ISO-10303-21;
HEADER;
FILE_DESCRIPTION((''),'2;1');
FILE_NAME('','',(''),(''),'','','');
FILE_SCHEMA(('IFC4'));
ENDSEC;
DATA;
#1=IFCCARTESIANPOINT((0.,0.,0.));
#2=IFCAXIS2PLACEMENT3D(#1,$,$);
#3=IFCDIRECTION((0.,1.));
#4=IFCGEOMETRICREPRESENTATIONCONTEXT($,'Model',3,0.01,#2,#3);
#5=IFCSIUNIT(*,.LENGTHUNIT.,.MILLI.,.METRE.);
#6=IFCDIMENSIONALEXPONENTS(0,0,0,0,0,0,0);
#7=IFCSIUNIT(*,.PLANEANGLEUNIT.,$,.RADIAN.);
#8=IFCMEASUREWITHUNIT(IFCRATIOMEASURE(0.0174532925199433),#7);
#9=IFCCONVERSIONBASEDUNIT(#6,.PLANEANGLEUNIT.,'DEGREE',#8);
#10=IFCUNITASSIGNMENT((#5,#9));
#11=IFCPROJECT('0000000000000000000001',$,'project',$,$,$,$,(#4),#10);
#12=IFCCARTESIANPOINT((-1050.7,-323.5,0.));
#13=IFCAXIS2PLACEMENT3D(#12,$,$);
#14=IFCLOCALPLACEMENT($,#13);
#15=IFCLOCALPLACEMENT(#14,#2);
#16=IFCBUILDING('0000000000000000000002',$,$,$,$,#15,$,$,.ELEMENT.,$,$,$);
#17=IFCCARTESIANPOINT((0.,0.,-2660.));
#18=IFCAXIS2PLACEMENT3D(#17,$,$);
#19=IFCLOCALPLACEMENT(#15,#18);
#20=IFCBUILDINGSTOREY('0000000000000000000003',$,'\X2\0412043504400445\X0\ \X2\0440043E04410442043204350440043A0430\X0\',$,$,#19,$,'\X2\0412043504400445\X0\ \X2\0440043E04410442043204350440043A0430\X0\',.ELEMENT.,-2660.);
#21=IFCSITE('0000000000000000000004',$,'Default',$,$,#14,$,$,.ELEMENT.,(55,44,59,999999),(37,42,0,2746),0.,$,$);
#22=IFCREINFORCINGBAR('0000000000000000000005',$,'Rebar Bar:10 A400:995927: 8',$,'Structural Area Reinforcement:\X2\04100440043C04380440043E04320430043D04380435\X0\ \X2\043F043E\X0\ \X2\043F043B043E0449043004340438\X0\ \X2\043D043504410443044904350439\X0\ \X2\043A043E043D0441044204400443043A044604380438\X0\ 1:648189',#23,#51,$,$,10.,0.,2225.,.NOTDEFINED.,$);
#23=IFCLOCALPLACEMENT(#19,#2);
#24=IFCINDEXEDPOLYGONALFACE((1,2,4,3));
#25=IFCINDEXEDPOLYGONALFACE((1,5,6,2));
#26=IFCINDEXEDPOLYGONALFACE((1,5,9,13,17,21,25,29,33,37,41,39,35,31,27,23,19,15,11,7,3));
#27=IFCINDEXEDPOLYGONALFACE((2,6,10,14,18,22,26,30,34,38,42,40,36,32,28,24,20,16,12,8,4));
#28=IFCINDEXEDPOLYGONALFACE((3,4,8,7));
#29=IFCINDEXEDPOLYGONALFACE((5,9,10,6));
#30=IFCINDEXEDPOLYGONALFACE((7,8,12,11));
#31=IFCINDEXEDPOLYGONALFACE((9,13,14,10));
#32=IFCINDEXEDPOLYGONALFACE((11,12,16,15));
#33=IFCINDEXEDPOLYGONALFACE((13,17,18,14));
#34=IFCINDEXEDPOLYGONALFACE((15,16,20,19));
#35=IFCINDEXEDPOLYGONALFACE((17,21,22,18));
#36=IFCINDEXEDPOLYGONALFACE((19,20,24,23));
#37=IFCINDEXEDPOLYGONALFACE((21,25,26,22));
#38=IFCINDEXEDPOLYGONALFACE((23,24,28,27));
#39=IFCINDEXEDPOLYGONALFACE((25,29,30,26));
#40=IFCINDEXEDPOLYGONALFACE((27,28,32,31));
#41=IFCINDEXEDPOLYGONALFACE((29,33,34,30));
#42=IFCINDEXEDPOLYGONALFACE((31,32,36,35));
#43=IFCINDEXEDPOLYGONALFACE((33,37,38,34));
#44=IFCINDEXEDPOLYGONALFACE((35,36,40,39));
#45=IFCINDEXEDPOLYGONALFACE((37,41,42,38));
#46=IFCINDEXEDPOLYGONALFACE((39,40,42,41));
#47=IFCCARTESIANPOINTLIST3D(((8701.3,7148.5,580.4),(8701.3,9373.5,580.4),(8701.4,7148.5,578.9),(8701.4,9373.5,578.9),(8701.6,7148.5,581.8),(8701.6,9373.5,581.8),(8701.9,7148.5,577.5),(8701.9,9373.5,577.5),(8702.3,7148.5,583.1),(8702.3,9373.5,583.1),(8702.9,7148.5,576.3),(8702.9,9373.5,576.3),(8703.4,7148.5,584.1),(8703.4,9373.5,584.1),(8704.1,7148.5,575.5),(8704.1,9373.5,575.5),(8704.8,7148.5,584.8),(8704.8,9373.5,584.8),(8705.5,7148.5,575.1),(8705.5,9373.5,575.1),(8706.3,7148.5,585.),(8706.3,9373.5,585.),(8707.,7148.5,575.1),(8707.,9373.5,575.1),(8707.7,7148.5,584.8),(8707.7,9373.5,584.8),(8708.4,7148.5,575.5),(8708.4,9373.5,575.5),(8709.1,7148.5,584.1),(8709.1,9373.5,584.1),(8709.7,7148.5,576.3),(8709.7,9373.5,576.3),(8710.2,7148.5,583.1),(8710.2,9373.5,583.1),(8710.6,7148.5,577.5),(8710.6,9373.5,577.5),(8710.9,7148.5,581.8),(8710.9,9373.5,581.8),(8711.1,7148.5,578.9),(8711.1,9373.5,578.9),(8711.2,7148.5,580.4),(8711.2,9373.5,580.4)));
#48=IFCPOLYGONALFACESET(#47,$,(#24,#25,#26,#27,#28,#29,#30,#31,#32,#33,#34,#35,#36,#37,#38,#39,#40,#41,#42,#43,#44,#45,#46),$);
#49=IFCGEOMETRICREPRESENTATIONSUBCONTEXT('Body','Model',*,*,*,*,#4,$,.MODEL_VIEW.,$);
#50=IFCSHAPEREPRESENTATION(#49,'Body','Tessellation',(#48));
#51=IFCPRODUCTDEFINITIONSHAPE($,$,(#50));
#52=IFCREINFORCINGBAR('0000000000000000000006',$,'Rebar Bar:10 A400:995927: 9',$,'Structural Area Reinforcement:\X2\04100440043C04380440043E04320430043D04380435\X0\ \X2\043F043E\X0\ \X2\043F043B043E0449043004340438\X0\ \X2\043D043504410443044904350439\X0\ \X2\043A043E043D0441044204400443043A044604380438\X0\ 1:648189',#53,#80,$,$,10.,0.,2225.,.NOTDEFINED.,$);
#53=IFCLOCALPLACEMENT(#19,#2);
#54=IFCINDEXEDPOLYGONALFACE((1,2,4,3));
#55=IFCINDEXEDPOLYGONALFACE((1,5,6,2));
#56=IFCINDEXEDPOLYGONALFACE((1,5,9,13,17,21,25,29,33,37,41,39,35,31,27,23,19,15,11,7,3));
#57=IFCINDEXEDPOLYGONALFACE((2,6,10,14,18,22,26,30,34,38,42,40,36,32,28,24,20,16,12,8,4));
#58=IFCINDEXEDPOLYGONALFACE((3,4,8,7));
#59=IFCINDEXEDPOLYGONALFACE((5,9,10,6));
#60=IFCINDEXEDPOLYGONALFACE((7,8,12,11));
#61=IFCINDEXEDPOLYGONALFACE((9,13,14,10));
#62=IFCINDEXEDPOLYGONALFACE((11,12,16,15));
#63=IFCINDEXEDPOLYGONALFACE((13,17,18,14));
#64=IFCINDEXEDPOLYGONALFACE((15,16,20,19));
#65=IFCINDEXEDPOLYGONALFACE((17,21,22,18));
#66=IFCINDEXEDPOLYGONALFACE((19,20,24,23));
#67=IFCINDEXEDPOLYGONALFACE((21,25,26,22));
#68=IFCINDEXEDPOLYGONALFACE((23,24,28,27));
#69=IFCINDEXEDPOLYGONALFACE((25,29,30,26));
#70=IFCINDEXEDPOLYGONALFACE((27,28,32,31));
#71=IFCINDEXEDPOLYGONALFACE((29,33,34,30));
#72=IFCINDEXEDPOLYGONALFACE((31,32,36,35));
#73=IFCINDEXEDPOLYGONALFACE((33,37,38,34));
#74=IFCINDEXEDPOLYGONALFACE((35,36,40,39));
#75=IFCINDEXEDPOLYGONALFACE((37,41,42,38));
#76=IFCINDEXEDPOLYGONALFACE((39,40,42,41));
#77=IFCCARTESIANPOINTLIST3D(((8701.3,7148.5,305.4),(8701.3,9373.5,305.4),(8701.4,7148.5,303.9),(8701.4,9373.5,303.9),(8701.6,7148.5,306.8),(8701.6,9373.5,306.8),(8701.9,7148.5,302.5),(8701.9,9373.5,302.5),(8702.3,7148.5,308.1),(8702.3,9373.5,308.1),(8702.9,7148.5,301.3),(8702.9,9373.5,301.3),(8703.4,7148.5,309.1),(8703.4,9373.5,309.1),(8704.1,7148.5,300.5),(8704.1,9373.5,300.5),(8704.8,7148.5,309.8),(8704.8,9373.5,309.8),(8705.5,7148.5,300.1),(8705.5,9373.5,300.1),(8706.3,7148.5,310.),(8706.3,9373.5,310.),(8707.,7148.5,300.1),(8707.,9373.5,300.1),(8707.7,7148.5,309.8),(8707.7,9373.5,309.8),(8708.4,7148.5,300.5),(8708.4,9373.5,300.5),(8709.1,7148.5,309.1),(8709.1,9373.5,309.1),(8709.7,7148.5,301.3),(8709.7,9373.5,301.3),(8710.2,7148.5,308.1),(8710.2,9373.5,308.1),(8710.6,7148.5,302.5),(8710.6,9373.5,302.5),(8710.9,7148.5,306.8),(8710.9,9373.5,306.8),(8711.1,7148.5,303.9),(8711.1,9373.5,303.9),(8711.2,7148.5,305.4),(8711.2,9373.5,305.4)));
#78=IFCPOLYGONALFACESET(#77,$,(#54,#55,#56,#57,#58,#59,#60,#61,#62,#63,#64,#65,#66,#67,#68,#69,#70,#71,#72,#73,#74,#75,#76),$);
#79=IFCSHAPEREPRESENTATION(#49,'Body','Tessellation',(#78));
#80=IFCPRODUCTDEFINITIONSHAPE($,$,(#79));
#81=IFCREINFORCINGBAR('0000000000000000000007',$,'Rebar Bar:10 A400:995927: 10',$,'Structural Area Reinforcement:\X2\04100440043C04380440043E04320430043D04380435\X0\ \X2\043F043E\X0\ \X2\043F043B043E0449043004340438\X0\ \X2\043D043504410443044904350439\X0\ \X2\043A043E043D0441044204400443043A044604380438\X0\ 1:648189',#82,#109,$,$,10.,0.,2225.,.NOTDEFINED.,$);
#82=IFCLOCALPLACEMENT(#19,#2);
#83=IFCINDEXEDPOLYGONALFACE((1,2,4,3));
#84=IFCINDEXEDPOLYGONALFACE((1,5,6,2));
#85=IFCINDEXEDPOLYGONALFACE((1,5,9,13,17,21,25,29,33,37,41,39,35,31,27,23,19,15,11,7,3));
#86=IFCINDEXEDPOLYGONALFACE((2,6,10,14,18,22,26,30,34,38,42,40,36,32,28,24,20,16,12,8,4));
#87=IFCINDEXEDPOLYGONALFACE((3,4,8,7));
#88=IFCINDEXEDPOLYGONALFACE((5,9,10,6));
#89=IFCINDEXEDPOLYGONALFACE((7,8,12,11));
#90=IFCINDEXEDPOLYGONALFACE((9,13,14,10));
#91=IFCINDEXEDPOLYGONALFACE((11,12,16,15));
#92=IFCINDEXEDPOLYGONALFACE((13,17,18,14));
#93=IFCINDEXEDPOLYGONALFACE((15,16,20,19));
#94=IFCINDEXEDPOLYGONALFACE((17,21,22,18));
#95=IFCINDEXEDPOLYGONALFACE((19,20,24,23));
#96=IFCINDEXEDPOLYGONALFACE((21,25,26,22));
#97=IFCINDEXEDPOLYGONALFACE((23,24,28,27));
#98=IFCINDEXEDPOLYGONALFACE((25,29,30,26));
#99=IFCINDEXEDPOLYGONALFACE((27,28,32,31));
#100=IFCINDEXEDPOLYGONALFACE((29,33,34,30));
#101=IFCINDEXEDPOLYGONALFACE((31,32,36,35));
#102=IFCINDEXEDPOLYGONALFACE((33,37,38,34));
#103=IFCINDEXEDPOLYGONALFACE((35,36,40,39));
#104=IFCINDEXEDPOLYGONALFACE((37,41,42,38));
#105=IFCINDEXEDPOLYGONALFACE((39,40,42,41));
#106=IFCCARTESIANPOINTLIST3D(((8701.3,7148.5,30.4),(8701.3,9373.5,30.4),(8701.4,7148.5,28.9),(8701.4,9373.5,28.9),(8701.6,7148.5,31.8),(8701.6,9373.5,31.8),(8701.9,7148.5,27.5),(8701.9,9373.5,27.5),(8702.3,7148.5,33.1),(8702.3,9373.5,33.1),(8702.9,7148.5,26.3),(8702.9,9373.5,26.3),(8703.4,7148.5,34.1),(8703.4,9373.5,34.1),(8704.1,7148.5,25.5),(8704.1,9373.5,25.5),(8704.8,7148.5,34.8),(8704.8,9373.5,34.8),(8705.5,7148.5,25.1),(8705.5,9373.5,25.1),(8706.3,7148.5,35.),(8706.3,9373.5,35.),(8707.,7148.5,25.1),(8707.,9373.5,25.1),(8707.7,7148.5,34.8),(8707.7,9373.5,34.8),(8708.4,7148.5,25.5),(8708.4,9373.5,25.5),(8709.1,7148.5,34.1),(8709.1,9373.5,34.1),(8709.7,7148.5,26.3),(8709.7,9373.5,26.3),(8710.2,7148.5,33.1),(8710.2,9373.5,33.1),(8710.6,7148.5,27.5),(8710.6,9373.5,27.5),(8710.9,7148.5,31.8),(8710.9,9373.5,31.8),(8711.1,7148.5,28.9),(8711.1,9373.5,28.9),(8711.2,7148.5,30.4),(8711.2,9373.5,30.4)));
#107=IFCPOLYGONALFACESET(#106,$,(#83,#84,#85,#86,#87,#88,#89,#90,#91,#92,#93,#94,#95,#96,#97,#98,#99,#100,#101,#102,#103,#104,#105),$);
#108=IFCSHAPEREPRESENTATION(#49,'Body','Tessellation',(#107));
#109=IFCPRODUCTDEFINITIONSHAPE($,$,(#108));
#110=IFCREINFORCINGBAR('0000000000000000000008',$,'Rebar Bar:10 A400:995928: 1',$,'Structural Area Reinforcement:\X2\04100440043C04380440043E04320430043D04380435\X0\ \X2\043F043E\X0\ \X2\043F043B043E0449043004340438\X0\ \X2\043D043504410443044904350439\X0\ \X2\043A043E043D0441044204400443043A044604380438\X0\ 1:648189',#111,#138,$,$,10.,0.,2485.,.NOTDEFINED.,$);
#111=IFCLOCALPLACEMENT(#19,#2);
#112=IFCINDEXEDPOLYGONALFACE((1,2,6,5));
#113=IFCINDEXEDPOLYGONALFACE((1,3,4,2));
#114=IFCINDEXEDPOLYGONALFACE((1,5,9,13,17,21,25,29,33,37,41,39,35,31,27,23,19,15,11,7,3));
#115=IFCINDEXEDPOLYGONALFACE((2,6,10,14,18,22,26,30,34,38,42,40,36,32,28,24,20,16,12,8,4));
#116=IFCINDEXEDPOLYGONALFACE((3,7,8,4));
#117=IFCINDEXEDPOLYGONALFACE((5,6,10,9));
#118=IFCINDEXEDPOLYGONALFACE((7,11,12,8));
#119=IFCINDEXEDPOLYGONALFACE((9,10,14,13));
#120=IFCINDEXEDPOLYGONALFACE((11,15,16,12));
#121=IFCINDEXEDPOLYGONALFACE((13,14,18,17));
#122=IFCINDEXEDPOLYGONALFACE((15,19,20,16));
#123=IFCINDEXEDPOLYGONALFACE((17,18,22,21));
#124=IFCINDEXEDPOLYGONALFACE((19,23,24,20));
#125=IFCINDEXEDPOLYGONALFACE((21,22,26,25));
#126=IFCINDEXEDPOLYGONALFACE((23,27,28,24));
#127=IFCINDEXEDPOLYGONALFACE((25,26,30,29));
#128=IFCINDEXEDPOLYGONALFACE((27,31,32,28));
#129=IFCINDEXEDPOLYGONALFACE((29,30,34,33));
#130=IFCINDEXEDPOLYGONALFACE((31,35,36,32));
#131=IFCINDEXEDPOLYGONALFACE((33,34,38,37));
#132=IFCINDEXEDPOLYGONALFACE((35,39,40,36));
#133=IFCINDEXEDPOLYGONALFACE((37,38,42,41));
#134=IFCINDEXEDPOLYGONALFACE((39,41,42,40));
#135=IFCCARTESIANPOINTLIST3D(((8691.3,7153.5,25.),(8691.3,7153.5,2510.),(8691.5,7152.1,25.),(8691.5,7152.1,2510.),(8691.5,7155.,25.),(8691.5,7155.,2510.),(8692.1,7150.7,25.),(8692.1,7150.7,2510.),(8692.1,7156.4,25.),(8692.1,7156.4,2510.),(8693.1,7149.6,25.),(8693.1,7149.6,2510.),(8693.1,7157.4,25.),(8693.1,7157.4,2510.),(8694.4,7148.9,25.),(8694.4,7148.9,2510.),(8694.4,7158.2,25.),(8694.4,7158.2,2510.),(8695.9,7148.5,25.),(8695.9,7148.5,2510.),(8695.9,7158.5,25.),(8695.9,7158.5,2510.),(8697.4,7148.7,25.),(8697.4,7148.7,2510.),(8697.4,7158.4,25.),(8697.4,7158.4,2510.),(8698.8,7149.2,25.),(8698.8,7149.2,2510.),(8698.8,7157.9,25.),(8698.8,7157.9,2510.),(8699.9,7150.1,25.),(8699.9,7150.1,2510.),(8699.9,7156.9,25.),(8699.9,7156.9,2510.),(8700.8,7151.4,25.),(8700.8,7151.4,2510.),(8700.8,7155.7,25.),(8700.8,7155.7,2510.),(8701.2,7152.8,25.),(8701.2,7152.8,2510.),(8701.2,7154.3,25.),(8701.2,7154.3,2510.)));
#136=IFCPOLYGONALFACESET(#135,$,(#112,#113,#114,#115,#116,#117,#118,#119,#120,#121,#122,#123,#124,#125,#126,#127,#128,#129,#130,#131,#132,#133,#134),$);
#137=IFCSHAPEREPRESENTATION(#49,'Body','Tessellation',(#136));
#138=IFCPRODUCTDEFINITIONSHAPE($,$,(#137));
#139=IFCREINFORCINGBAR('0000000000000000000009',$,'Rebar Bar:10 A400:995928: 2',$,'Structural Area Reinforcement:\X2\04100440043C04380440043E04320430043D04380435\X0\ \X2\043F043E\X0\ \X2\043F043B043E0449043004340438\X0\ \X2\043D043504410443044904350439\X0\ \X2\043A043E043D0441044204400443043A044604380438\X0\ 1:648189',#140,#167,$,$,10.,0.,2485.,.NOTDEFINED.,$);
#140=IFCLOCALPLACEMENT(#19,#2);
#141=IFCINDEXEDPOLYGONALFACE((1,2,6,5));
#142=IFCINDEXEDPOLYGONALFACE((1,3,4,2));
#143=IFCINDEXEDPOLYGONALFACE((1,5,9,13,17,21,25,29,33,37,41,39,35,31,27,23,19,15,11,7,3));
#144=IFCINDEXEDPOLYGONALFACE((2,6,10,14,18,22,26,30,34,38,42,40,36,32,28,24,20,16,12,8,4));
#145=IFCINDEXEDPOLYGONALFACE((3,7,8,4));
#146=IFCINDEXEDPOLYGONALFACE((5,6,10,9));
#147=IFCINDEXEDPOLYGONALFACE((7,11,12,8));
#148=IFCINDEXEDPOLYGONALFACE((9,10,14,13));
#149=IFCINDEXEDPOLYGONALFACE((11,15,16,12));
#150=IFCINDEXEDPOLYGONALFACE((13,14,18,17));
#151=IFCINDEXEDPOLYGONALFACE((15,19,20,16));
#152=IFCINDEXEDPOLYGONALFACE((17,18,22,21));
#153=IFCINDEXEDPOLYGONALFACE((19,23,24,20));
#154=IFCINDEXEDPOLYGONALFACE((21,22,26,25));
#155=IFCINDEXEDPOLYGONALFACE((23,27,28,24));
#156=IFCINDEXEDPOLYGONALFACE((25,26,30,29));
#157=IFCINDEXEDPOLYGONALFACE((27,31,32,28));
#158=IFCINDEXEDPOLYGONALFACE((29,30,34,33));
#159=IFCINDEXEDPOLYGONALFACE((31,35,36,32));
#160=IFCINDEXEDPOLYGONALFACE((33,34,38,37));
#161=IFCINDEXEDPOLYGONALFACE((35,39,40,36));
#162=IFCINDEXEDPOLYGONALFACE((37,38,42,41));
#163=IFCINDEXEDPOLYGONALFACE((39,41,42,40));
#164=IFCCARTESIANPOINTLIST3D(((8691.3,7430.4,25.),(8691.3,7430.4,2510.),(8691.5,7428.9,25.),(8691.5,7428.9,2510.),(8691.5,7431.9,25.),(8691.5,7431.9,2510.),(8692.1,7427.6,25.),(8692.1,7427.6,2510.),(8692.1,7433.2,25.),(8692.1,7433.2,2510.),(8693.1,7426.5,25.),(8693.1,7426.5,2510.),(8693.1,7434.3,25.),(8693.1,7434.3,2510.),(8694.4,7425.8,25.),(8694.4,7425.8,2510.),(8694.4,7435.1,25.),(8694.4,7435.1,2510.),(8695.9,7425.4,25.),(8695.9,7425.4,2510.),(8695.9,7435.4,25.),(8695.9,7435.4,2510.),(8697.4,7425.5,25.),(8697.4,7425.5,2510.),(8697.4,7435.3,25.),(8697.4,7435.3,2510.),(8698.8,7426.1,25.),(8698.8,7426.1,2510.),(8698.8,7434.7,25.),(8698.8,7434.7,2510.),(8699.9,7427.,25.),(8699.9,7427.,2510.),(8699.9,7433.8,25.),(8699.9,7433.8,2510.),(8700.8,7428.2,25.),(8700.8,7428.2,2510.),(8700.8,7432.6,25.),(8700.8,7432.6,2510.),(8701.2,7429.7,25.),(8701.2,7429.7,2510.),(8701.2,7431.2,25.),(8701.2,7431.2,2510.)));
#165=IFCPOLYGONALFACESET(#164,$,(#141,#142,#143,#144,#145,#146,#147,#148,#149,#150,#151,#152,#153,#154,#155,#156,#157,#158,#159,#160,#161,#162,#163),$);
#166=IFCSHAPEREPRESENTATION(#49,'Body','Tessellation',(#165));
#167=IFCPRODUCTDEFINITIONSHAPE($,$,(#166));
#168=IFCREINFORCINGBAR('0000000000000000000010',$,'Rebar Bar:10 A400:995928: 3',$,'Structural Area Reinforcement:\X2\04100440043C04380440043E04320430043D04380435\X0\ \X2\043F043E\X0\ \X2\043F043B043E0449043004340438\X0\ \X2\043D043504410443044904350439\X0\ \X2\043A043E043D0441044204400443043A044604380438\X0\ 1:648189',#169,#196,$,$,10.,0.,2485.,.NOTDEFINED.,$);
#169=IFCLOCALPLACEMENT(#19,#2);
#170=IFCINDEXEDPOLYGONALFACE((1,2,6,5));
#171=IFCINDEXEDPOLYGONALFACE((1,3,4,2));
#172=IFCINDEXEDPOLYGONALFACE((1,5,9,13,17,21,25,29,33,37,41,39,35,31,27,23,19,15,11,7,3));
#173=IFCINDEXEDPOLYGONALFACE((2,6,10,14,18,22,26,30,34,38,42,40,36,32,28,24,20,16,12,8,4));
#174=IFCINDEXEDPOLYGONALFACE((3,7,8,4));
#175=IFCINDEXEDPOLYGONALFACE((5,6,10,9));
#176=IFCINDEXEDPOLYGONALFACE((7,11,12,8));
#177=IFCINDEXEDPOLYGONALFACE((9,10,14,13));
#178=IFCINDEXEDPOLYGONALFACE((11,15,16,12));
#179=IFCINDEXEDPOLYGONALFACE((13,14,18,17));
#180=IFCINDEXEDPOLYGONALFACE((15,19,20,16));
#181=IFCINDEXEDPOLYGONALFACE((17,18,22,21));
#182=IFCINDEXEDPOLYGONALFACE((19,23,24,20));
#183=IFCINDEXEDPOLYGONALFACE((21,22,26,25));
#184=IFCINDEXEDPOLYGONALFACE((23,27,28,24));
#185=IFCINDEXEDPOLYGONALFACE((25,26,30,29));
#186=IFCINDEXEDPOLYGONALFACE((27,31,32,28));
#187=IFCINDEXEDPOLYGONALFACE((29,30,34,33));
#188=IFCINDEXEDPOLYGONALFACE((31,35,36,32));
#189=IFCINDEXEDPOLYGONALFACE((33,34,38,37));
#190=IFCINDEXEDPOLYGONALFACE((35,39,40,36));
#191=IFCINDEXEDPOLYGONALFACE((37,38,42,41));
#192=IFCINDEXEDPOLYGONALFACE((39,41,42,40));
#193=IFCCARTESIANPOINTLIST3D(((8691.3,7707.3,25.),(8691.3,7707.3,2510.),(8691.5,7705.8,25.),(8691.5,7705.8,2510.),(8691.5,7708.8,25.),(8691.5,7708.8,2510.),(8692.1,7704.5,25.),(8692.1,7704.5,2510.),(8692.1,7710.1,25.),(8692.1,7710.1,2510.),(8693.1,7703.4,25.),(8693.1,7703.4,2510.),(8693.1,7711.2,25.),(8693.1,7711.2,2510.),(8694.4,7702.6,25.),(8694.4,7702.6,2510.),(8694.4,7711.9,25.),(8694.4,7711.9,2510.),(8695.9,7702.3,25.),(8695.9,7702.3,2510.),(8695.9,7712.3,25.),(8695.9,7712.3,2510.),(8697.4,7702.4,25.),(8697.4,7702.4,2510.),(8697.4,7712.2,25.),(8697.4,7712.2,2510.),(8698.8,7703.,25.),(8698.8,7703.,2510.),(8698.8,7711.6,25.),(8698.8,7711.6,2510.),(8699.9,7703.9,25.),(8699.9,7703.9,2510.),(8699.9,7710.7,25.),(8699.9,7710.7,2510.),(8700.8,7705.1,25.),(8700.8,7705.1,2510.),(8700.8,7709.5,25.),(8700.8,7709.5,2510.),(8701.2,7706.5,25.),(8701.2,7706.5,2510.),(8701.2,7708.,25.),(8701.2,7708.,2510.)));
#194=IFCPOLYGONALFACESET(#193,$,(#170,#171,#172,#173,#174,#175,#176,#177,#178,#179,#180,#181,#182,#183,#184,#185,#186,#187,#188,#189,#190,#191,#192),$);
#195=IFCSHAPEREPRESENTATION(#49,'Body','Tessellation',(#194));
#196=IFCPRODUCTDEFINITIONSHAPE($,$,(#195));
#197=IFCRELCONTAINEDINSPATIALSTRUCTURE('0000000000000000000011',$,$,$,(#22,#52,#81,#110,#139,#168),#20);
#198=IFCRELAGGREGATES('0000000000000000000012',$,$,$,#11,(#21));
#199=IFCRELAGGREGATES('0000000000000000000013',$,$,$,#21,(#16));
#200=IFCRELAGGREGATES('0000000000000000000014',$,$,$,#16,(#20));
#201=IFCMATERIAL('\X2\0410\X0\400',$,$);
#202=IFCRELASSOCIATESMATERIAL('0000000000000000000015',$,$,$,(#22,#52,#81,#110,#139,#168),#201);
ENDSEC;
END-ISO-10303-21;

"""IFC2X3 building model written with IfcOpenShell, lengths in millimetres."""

from ifc_helpers import new_model, entity, si_unit, converted_unit, direction, frame, origin, place, context, subcontext, project, spatial, material, element, save


model = new_model("IFC2X3")

# Units and contexts
model_context = context("Model", 3, precision=0.01, world=origin(), true_north=direction((0.0, 1.0)))
body_context = subcontext(model_context, "Body", "Model", "MODEL_VIEW")
ifc_project = project(units=[si_unit("LENGTHUNIT", "METRE", prefix="MILLI"), converted_unit("PLANEANGLEUNIT", "DEGREE", entity("IfcRatioMeasure", 0.0174532925199433), si_unit("PLANEANGLEUNIT", "RADIAN"), dimensions=[0, 0, 0, 0, 0, 0, 0])], contexts=[model_context])

# Site, building, storey
site_placement = place(None, frame((-1050.7, -323.5, 0.0)))
site = spatial("IfcSite", under=ifc_project, at=site_placement, Name="Default", CompositionType="ELEMENT", RefLatitude=(55, 44, 59, 999999), RefLongitude=(37, 42, 0, 2746), RefElevation=0.0)
building_placement = place(site_placement, origin())
building = spatial("IfcBuilding", under=site, at=building_placement, CompositionType="ELEMENT")
storey_placement = place(building_placement, frame((0.0, 0.0, -2660.0)))
storey = spatial("IfcBuildingStorey", under=building, at=storey_placement, Name="Верх ростверка", LongName="Верх ростверка", CompositionType="ELEMENT", Elevation=-2660.0)

# Reinforcing bars
ifc_material = material(Name="А400")
reinforcing_bar_1_placement = place(storey_placement, origin())
element("IfcReinforcingBar", 1, at=reinforcing_bar_1_placement, inside=storey, material=ifc_material, Name="Rebar Bar:10 A400:995927: 8", ObjectType="Structural Area Reinforcement:Армирование по площади несущей конструкции 1:648189", BarLength=2225.0, BarRole="NOTDEFINED", CrossSectionArea=0.0, NominalDiameter=10.0, context=body_context, shape_type="AdvancedSweptSolid", body=[
    entity("IfcSweptDiskSolid", entity("IfcCompositeCurve", [entity("IfcCompositeCurveSegment", "CONTINUOUS", True, entity("IfcPolyline", [entity("IfcCartesianPoint", [8706.3, 7148.5, 580.0]), entity("IfcCartesianPoint", [8706.3, 9373.5, 580.0])]))], False), 5.0, None, 0.0, 1.0),
])
reinforcing_bar_2_placement = place(storey_placement, origin())
element("IfcReinforcingBar", 2, at=reinforcing_bar_2_placement, inside=storey, material=ifc_material, Name="Rebar Bar:10 A400:995927: 9", ObjectType="Structural Area Reinforcement:Армирование по площади несущей конструкции 1:648189", BarLength=2225.0, BarRole="NOTDEFINED", CrossSectionArea=0.0, NominalDiameter=10.0, context=body_context, shape_type="AdvancedSweptSolid", body=[
    entity("IfcSweptDiskSolid", entity("IfcCompositeCurve", [entity("IfcCompositeCurveSegment", "CONTINUOUS", True, entity("IfcPolyline", [entity("IfcCartesianPoint", [8706.3, 7148.5, 305.0]), entity("IfcCartesianPoint", [8706.3, 9373.5, 305.0])]))], False), 5.0, None, 0.0, 1.0),
])
reinforcing_bar_3_placement = place(storey_placement, origin())
element("IfcReinforcingBar", 3, at=reinforcing_bar_3_placement, inside=storey, material=ifc_material, Name="Rebar Bar:10 A400:995927: 10", ObjectType="Structural Area Reinforcement:Армирование по площади несущей конструкции 1:648189", BarLength=2225.0, BarRole="NOTDEFINED", CrossSectionArea=0.0, NominalDiameter=10.0, context=body_context, shape_type="AdvancedSweptSolid", body=[
    entity("IfcSweptDiskSolid", entity("IfcCompositeCurve", [entity("IfcCompositeCurveSegment", "CONTINUOUS", True, entity("IfcPolyline", [entity("IfcCartesianPoint", [8706.3, 7148.5, 30.0]), entity("IfcCartesianPoint", [8706.3, 9373.5, 30.0])]))], False), 5.0, None, 0.0, 1.0),
])
reinforcing_bar_4_placement = place(storey_placement, origin())
element("IfcReinforcingBar", 4, at=reinforcing_bar_4_placement, inside=storey, material=ifc_material, Name="Rebar Bar:10 A400:995928: 1", ObjectType="Structural Area Reinforcement:Армирование по площади несущей конструкции 1:648189", BarLength=2485.0, BarRole="NOTDEFINED", CrossSectionArea=0.0, NominalDiameter=10.0, context=body_context, shape_type="AdvancedSweptSolid", body=[
    entity("IfcSweptDiskSolid", entity("IfcCompositeCurve", [entity("IfcCompositeCurveSegment", "CONTINUOUS", True, entity("IfcPolyline", [entity("IfcCartesianPoint", [8696.3, 7153.5, 2510.0]), entity("IfcCartesianPoint", [8696.3, 7153.5, 25.0])]))], False), 5.0, None, 0.0, 1.0),
])
reinforcing_bar_5_placement = place(storey_placement, origin())
element("IfcReinforcingBar", 5, at=reinforcing_bar_5_placement, inside=storey, material=ifc_material, Name="Rebar Bar:10 A400:995928: 2", ObjectType="Structural Area Reinforcement:Армирование по площади несущей конструкции 1:648189", BarLength=2485.0, BarRole="NOTDEFINED", CrossSectionArea=0.0, NominalDiameter=10.0, context=body_context, shape_type="AdvancedSweptSolid", body=[
    entity("IfcSweptDiskSolid", entity("IfcCompositeCurve", [entity("IfcCompositeCurveSegment", "CONTINUOUS", True, entity("IfcPolyline", [entity("IfcCartesianPoint", [8696.3, 7430.4, 2510.0]), entity("IfcCartesianPoint", [8696.3, 7430.4, 25.0])]))], False), 5.0, None, 0.0, 1.0),
])
reinforcing_bar_6_placement = place(storey_placement, origin())
element("IfcReinforcingBar", 6, at=reinforcing_bar_6_placement, inside=storey, material=ifc_material, Name="Rebar Bar:10 A400:995928: 3", ObjectType="Structural Area Reinforcement:Армирование по площади несущей конструкции 1:648189", BarLength=2485.0, BarRole="NOTDEFINED", CrossSectionArea=0.0, NominalDiameter=10.0, context=body_context, shape_type="AdvancedSweptSolid", body=[
    entity("IfcSweptDiskSolid", entity("IfcCompositeCurve", [entity("IfcCompositeCurveSegment", "CONTINUOUS", True, entity("IfcPolyline", [entity("IfcCartesianPoint", [8696.3, 7707.3, 2510.0]), entity("IfcCartesianPoint", [8696.3, 7707.3, 25.0])]))], False), 5.0, None, 0.0, 1.0),
])

save(model, "model.ifc")
